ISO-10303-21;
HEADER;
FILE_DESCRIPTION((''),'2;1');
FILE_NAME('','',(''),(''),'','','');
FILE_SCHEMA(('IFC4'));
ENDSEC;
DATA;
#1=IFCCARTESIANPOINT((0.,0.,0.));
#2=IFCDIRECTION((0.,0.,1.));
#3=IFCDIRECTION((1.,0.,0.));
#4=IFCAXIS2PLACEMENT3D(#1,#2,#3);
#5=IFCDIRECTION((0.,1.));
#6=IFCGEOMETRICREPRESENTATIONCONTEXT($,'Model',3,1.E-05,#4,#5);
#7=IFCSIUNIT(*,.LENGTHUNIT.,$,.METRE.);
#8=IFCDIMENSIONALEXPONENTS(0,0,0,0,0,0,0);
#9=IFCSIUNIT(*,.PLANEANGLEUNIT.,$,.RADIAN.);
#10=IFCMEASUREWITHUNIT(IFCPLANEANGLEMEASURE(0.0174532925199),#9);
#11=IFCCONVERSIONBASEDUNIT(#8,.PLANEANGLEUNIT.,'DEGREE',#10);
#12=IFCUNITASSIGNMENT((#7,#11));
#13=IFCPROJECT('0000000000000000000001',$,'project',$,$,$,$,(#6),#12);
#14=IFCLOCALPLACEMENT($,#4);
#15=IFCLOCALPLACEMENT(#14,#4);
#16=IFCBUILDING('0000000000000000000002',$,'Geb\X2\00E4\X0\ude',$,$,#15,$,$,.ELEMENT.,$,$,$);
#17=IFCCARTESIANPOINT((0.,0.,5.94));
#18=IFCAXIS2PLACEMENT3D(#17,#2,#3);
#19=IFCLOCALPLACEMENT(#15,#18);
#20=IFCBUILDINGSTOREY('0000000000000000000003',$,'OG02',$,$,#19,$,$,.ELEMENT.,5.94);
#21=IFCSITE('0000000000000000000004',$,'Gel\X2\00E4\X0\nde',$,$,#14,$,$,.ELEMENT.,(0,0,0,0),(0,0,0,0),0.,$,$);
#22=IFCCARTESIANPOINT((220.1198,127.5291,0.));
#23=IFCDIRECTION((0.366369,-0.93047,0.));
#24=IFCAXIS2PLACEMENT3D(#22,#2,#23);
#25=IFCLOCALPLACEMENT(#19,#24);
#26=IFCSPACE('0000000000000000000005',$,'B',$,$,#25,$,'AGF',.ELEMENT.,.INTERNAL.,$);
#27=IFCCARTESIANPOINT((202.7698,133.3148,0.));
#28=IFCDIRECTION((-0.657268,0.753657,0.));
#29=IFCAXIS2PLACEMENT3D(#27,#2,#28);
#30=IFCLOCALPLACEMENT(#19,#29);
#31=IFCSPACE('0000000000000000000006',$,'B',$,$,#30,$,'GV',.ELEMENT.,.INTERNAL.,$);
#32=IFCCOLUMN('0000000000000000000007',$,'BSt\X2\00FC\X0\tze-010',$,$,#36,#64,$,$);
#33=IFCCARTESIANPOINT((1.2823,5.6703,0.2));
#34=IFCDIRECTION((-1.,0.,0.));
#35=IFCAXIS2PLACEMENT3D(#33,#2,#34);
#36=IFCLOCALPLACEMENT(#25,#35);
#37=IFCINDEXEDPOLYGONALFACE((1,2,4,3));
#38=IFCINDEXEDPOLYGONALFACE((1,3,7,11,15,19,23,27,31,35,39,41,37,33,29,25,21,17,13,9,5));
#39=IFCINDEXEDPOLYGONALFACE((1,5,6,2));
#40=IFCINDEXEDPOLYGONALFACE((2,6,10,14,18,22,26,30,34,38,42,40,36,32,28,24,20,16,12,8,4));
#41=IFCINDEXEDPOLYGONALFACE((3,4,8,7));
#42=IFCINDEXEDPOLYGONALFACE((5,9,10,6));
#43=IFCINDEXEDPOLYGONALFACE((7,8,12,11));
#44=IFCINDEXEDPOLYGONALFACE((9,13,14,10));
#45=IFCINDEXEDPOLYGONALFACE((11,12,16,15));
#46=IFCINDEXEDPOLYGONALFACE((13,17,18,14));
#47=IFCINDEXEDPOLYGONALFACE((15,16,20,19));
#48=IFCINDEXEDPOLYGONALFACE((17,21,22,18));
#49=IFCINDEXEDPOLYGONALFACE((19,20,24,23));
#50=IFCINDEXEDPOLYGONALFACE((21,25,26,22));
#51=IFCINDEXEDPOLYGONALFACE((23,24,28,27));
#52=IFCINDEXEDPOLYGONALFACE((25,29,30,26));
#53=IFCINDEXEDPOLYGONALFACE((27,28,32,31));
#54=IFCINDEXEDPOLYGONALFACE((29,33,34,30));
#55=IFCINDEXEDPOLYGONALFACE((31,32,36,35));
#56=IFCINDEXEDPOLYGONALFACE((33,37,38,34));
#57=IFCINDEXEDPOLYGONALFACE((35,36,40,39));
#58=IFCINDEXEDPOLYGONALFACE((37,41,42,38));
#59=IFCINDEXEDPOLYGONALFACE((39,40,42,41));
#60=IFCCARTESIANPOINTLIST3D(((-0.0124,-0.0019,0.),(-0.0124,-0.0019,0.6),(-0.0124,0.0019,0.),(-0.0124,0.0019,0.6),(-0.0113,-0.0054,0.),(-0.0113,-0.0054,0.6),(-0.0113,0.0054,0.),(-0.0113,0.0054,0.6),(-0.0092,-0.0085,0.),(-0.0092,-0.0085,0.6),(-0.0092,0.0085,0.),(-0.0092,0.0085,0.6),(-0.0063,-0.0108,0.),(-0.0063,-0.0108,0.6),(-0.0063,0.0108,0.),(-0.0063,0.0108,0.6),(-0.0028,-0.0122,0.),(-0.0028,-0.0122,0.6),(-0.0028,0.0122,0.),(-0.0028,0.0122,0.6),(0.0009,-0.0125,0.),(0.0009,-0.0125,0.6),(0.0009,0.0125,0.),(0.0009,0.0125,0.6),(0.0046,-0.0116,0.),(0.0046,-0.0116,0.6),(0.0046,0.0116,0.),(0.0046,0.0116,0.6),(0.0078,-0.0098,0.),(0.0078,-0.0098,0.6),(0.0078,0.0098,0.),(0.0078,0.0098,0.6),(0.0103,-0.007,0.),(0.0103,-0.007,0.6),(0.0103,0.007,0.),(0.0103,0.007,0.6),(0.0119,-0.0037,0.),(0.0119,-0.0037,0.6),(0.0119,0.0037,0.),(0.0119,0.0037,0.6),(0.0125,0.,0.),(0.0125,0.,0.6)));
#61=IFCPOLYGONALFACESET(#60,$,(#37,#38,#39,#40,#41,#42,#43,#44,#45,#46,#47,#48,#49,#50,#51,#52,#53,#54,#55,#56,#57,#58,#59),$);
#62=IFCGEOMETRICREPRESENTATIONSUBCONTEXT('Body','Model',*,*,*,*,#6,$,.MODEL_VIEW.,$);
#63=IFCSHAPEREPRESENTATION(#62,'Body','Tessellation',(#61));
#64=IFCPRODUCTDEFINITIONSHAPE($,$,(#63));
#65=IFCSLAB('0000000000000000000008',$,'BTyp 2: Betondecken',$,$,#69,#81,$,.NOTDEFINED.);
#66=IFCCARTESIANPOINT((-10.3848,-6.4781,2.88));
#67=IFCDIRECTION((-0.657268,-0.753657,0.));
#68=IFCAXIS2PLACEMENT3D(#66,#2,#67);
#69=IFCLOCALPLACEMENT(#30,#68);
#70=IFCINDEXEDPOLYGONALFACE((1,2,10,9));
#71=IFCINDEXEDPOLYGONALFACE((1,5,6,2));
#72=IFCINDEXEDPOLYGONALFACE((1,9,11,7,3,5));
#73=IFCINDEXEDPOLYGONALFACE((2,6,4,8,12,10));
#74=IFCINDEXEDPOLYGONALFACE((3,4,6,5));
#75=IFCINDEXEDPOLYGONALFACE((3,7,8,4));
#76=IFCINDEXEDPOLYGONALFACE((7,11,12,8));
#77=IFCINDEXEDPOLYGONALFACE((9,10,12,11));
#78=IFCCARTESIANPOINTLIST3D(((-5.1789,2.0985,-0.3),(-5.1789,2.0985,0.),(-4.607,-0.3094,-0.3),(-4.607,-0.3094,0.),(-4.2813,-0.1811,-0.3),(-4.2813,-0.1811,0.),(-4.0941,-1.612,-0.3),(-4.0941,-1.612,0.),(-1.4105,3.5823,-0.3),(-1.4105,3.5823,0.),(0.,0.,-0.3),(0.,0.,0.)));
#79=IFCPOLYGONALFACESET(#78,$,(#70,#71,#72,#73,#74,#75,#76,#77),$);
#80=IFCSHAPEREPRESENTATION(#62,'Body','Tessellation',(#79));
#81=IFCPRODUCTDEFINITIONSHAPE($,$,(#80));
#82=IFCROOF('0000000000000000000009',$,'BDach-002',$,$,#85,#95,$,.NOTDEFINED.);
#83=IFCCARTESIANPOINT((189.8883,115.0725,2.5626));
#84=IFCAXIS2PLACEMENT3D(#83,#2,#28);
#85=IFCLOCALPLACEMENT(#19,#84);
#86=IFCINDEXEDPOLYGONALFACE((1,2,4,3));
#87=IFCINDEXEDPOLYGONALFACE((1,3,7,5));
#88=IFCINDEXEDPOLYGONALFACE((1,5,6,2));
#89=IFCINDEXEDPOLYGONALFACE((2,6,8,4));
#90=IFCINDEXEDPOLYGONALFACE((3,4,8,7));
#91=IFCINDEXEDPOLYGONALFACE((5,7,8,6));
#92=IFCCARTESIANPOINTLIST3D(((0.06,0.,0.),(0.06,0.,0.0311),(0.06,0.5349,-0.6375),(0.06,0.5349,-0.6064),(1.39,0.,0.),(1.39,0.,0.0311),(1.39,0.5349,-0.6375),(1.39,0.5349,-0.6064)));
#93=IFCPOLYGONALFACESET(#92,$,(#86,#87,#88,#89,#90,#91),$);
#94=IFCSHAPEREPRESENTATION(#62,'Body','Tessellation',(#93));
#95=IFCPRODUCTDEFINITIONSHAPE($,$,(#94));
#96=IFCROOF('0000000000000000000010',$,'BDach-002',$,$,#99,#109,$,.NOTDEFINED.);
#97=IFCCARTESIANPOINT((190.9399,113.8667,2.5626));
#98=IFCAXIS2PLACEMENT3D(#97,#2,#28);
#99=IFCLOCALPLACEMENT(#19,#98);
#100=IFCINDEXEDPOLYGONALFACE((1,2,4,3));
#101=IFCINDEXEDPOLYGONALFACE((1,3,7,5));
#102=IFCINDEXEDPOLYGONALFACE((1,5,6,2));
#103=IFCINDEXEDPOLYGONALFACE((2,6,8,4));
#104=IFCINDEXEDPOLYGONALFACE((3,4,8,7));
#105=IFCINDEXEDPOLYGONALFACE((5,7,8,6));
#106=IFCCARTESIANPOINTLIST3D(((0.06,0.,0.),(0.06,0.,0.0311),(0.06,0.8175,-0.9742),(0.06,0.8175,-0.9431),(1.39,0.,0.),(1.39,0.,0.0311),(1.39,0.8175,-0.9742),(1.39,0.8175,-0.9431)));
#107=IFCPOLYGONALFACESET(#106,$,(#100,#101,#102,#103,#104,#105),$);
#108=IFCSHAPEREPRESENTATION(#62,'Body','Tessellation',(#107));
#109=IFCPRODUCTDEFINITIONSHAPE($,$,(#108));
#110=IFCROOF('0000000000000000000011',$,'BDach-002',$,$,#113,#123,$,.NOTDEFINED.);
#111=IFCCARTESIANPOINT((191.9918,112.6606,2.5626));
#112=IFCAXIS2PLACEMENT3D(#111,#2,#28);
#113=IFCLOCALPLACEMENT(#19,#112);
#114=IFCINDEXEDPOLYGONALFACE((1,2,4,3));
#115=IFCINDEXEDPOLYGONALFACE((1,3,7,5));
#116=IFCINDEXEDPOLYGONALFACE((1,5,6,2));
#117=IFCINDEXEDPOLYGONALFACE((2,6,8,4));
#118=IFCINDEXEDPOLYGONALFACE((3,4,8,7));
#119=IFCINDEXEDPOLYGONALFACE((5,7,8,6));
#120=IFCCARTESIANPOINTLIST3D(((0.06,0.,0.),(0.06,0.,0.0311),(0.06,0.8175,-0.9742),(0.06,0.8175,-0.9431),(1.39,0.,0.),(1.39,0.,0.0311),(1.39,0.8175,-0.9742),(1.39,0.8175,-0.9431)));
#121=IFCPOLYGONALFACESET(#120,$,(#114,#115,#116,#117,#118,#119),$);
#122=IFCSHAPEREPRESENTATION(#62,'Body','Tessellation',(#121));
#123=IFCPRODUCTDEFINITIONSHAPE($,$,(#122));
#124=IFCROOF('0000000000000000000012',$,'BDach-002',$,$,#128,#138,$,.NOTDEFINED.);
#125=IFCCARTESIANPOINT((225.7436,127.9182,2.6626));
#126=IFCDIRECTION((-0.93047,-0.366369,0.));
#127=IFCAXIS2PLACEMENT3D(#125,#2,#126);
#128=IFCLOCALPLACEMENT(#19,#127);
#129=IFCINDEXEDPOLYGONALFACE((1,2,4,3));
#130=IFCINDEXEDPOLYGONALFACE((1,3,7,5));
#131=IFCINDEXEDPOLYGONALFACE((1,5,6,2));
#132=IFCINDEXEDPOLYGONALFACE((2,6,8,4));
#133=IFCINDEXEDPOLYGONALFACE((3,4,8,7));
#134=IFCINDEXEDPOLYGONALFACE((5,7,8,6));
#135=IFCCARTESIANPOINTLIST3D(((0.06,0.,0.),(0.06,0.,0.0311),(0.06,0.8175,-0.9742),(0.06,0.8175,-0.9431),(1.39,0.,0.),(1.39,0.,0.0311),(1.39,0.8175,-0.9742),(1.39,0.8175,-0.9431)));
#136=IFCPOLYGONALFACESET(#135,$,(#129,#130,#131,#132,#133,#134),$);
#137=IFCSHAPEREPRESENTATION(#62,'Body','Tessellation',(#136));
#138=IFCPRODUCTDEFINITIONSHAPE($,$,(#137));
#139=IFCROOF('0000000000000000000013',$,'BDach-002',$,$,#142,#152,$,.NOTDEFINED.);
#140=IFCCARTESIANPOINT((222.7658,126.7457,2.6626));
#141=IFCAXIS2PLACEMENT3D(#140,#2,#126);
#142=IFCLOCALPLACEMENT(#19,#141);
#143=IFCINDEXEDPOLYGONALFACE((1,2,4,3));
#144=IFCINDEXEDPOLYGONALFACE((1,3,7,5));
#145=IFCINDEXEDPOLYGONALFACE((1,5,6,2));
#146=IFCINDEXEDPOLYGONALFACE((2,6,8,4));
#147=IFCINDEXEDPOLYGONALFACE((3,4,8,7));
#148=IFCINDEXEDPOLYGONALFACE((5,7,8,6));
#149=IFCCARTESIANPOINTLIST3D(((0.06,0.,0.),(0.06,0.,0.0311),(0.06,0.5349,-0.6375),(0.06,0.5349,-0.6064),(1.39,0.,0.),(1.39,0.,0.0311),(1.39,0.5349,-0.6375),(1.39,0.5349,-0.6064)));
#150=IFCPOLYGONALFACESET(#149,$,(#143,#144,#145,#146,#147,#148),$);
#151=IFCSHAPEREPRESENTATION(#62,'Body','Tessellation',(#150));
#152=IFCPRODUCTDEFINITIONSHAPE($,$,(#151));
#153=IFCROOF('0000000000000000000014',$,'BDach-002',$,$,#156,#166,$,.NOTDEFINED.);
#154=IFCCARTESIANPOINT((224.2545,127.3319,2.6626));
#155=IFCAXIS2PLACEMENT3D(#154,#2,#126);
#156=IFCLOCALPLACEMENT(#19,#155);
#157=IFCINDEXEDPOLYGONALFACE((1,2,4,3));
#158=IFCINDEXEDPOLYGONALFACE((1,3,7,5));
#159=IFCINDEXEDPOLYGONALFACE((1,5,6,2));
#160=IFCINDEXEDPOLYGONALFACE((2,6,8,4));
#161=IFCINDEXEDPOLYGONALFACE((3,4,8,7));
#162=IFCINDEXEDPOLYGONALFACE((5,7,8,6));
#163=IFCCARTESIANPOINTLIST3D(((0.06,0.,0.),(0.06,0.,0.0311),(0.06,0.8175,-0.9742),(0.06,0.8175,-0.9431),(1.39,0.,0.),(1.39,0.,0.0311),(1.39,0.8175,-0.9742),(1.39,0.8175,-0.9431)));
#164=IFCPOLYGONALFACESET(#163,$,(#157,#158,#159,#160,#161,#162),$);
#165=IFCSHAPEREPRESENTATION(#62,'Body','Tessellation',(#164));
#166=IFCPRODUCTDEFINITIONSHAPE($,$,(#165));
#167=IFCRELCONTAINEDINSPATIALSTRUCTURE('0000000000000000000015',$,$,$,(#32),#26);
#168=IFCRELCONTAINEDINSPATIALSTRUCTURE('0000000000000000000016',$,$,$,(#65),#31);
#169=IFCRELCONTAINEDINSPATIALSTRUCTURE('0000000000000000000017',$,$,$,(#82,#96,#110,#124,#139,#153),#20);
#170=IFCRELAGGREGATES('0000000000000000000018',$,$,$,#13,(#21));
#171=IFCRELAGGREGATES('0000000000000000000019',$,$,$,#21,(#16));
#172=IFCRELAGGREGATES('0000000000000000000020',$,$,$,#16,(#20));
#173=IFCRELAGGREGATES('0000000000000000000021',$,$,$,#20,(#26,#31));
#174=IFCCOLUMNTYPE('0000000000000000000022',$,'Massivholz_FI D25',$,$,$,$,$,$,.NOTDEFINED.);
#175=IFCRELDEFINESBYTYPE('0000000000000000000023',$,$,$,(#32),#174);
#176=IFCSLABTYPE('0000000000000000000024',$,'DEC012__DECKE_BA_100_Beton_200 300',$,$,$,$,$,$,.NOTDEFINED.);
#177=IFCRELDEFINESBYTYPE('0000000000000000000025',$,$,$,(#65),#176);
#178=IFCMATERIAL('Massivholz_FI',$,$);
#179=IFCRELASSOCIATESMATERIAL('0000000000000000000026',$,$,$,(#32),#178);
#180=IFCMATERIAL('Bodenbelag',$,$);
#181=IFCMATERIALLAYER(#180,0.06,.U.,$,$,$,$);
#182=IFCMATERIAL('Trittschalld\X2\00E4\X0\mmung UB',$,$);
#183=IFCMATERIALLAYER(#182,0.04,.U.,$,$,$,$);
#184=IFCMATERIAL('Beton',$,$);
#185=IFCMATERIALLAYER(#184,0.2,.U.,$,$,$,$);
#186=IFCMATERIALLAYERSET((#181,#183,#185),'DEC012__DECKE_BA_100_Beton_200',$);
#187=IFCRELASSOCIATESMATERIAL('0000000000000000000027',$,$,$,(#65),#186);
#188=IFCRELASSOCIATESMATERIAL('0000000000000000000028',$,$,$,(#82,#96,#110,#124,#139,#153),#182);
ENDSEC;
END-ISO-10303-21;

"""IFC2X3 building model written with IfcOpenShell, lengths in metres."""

from ifc_helpers import new_model, entity, si_unit, converted_unit, direction, frame, origin_with_axes, origin_2d_with_axis, place, context, subcontext, project, spatial, polyline, circle, outline, extrude, material, layer, layer_set, layer_usage, type_object, element, save


model = new_model("IFC2X3")

# Units and contexts
model_context = context("Model", 3, precision=1e-05, world=origin_with_axes(), true_north=direction((0.0, 1.0)))
body_context = subcontext(model_context, "Body", "Model", "MODEL_VIEW")
ifc_project = project(units=[si_unit("LENGTHUNIT", "METRE"), converted_unit("PLANEANGLEUNIT", "DEGREE", entity("IfcPlaneAngleMeasure", 0.0174532925199), si_unit("PLANEANGLEUNIT", "RADIAN"), dimensions=[0, 0, 0, 0, 0, 0, 0])], contexts=[model_context])

# Site, building, storey
site_placement = place(None, origin_with_axes())
site = spatial("IfcSite", under=ifc_project, at=site_placement, Name="Gelände", CompositionType="ELEMENT", RefLatitude=(0, 0, 0, 0), RefLongitude=(0, 0, 0, 0), RefElevation=0.0)
building_placement = place(site_placement, origin_with_axes())
building = spatial("IfcBuilding", under=site, at=building_placement, Name="Gebäude", CompositionType="ELEMENT")
storey_placement = place(building_placement, frame((0.0, 0.0, 5.94), z_axis=(0.0, 0.0, 1.0), x_axis=(1.0, 0.0, 0.0)))
storey = spatial("IfcBuildingStorey", under=building, at=storey_placement, Name="OG02", CompositionType="ELEMENT", Elevation=5.94)

# Shared definitions
ifc_material_1 = material(Name="Massivholz_FI")
column_type_1 = type_object("IfcColumnType", Name="Massivholz_FI D25", PredefinedType="NOTDEFINED")

# Shared definitions
space_1_placement = place(storey_placement, frame((220.1198, 127.5291, 0.0), z_axis=(0.0, 0.0, 1.0), x_axis=(0.366369, -0.93047, 0.0)))
space_1 = spatial("IfcSpace", under=storey, at=space_1_placement, Name="B", LongName="AGF", CompositionType="ELEMENT", InteriorOrExteriorSpace="INTERNAL")

# Column
for number, where, z_axis, x_axis, name in (
    (1, (1.2823, 5.6703, 0.2), (0.0, 0.0, 1.0), (-1.0, 0.0, 0.0), "BStütze-010"),
):
    element("IfcColumn", number, at=place(space_1_placement, frame(where, z_axis=z_axis, x_axis=x_axis)), inside=space_1, type_object=column_type_1, material=ifc_material_1, Name=name, context=body_context, shape_type="SweptSolid", body=[
        extrude(circle(Radius=0.0125, at=origin_2d_with_axis()), origin_with_axes(), (0.0, 0.0, 1.0), 0.6),
    ])

# Shared definitions
space_2_placement = place(storey_placement, frame((202.7698, 133.3148, 0.0), z_axis=(0.0, 0.0, 1.0), x_axis=(-0.657268, 0.753657, 0.0)))
space_2 = spatial("IfcSpace", under=storey, at=space_2_placement, Name="B", LongName="GV", CompositionType="ELEMENT", InteriorOrExteriorSpace="INTERNAL")

# Slab
ifc_material_2 = material(Name="Bodenbelag")
ifc_layer_1 = layer(ifc_material_2, 0.06, ventilated="UNKNOWN")
ifc_material_3 = material(Name="Trittschalldämmung UB")
ifc_layer_2 = layer(ifc_material_3, 0.04, ventilated="UNKNOWN")
ifc_material_4 = material(Name="Beton")
ifc_layer_3 = layer(ifc_material_4, 0.2, ventilated="UNKNOWN")
ifc_layer_set_1 = layer_set([ifc_layer_1, ifc_layer_2, ifc_layer_3], Name="DEC012__DECKE_BA_100_Beton_200")
ifc_layer_usage_1 = layer_usage(ifc_layer_set_1, "AXIS3", "NEGATIVE", 0.3)
slab_type_1 = type_object("IfcSlabType", Name="DEC012__DECKE_BA_100_Beton_200 300", PredefinedType="NOTDEFINED")
slab_1_placement = place(space_2_placement, frame((-10.3848, -6.4781, 2.88), z_axis=(0.0, 0.0, 1.0), x_axis=(-0.657268, -0.753657, 0.0)))
element("IfcSlab", 2, at=slab_1_placement, inside=space_2, type_object=slab_type_1, material=ifc_layer_usage_1, Name="BTyp 2: Betondecken", PredefinedType="NOTDEFINED", context=body_context, shape_type="SweptSolid", body=[
    extrude(outline(polyline([(0.0, 0.0), (-1.4105, 3.5823), (-5.1789, 2.0985), (-4.2813, -0.1811), (-4.607, -0.3094), (-4.0941, -1.612), (0.0, 0.0)])), frame((0.0, 0.0, -0.3), z_axis=(0.0, 0.0, 1.0), x_axis=(1.0, 0.0, 0.0)), (0.0, 0.0, 1.0), 0.3),
])

# Roofs
roof_1_placement = place(storey_placement, frame((189.8883, 115.0725, 2.5626), z_axis=(0.0, 0.0, 1.0), x_axis=(-0.657268, 0.753657, 0.0)))
element("IfcRoof", 3, at=roof_1_placement, inside=storey, material=ifc_material_3, Name="BDach-002", ShapeType="NOTDEFINED", context=body_context, shape_type="SweptSolid", body=[
    extrude(outline(polyline([(1.39, 0.0), (1.39, 0.8322), (0.06, 0.8322), (0.06, 0.0), (1.39, 0.0)])), frame((0.0, 0.0, 0.0), z_axis=(0.0, 0.766044, 0.642788), x_axis=(1.0, 0.0, 0.0)), (0.0, -0.766044, 0.642788), 0.0311),
])
roof_2_placement = place(storey_placement, frame((190.9399, 113.8667, 2.5626), z_axis=(0.0, 0.0, 1.0), x_axis=(-0.657268, 0.753657, 0.0)))
element("IfcRoof", 4, at=roof_2_placement, inside=storey, material=ifc_material_3, Name="BDach-002", ShapeType="NOTDEFINED", context=body_context, shape_type="SweptSolid", body=[
    extrude(outline(polyline([(1.39, 0.0), (1.39, 1.2717), (0.06, 1.2717), (0.06, 0.0), (1.39, 0.0)])), frame((0.0, 0.0, 0.0), z_axis=(0.0, 0.766044, 0.642788), x_axis=(1.0, 0.0, 0.0)), (0.0, -0.766044, 0.642788), 0.0311),
])
roof_3_placement = place(storey_placement, frame((191.9918, 112.6606, 2.5626), z_axis=(0.0, 0.0, 1.0), x_axis=(-0.657268, 0.753657, 0.0)))
element("IfcRoof", 5, at=roof_3_placement, inside=storey, material=ifc_material_3, Name="BDach-002", ShapeType="NOTDEFINED", context=body_context, shape_type="SweptSolid", body=[
    extrude(outline(polyline([(1.39, 0.0), (1.39, 1.2717), (0.06, 1.2717), (0.06, 0.0), (1.39, 0.0)])), frame((0.0, 0.0, 0.0), z_axis=(0.0, 0.766044, 0.642788), x_axis=(1.0, 0.0, 0.0)), (0.0, -0.766044, 0.642788), 0.0311),
])
roof_4_placement = place(storey_placement, frame((225.7436, 127.9182, 2.6626), z_axis=(0.0, 0.0, 1.0), x_axis=(-0.93047, -0.366369, 0.0)))
element("IfcRoof", 6, at=roof_4_placement, inside=storey, material=ifc_material_3, Name="BDach-002", ShapeType="NOTDEFINED", context=body_context, shape_type="SweptSolid", body=[
    extrude(outline(polyline([(1.39, 0.0), (1.39, 1.2717), (0.06, 1.2717), (0.06, 0.0), (1.39, 0.0)])), frame((0.0, 0.0, 0.0), z_axis=(0.0, 0.766044, 0.642788), x_axis=(1.0, 0.0, 0.0)), (0.0, -0.766044, 0.642788), 0.0311),
])
roof_5_placement = place(storey_placement, frame((222.7658, 126.7457, 2.6626), z_axis=(0.0, 0.0, 1.0), x_axis=(-0.93047, -0.366369, 0.0)))
element("IfcRoof", 7, at=roof_5_placement, inside=storey, material=ifc_material_3, Name="BDach-002", ShapeType="NOTDEFINED", context=body_context, shape_type="SweptSolid", body=[
    extrude(outline(polyline([(1.39, 0.0), (1.39, 0.8322), (0.06, 0.8322), (0.06, 0.0), (1.39, 0.0)])), frame((0.0, 0.0, 0.0), z_axis=(0.0, 0.766044, 0.642788), x_axis=(1.0, 0.0, 0.0)), (0.0, -0.766044, 0.642788), 0.0311),
])
roof_6_placement = place(storey_placement, frame((224.2545, 127.3319, 2.6626), z_axis=(0.0, 0.0, 1.0), x_axis=(-0.93047, -0.366369, 0.0)))
element("IfcRoof", 8, at=roof_6_placement, inside=storey, material=ifc_material_3, Name="BDach-002", ShapeType="NOTDEFINED", context=body_context, shape_type="SweptSolid", body=[
    extrude(outline(polyline([(1.39, 0.0), (1.39, 1.2717), (0.06, 1.2717), (0.06, 0.0), (1.39, 0.0)])), frame((0.0, 0.0, 0.0), z_axis=(0.0, 0.766044, 0.642788), x_axis=(1.0, 0.0, 0.0)), (0.0, -0.766044, 0.642788), 0.0311),
])

save(model, "model.ifc")
